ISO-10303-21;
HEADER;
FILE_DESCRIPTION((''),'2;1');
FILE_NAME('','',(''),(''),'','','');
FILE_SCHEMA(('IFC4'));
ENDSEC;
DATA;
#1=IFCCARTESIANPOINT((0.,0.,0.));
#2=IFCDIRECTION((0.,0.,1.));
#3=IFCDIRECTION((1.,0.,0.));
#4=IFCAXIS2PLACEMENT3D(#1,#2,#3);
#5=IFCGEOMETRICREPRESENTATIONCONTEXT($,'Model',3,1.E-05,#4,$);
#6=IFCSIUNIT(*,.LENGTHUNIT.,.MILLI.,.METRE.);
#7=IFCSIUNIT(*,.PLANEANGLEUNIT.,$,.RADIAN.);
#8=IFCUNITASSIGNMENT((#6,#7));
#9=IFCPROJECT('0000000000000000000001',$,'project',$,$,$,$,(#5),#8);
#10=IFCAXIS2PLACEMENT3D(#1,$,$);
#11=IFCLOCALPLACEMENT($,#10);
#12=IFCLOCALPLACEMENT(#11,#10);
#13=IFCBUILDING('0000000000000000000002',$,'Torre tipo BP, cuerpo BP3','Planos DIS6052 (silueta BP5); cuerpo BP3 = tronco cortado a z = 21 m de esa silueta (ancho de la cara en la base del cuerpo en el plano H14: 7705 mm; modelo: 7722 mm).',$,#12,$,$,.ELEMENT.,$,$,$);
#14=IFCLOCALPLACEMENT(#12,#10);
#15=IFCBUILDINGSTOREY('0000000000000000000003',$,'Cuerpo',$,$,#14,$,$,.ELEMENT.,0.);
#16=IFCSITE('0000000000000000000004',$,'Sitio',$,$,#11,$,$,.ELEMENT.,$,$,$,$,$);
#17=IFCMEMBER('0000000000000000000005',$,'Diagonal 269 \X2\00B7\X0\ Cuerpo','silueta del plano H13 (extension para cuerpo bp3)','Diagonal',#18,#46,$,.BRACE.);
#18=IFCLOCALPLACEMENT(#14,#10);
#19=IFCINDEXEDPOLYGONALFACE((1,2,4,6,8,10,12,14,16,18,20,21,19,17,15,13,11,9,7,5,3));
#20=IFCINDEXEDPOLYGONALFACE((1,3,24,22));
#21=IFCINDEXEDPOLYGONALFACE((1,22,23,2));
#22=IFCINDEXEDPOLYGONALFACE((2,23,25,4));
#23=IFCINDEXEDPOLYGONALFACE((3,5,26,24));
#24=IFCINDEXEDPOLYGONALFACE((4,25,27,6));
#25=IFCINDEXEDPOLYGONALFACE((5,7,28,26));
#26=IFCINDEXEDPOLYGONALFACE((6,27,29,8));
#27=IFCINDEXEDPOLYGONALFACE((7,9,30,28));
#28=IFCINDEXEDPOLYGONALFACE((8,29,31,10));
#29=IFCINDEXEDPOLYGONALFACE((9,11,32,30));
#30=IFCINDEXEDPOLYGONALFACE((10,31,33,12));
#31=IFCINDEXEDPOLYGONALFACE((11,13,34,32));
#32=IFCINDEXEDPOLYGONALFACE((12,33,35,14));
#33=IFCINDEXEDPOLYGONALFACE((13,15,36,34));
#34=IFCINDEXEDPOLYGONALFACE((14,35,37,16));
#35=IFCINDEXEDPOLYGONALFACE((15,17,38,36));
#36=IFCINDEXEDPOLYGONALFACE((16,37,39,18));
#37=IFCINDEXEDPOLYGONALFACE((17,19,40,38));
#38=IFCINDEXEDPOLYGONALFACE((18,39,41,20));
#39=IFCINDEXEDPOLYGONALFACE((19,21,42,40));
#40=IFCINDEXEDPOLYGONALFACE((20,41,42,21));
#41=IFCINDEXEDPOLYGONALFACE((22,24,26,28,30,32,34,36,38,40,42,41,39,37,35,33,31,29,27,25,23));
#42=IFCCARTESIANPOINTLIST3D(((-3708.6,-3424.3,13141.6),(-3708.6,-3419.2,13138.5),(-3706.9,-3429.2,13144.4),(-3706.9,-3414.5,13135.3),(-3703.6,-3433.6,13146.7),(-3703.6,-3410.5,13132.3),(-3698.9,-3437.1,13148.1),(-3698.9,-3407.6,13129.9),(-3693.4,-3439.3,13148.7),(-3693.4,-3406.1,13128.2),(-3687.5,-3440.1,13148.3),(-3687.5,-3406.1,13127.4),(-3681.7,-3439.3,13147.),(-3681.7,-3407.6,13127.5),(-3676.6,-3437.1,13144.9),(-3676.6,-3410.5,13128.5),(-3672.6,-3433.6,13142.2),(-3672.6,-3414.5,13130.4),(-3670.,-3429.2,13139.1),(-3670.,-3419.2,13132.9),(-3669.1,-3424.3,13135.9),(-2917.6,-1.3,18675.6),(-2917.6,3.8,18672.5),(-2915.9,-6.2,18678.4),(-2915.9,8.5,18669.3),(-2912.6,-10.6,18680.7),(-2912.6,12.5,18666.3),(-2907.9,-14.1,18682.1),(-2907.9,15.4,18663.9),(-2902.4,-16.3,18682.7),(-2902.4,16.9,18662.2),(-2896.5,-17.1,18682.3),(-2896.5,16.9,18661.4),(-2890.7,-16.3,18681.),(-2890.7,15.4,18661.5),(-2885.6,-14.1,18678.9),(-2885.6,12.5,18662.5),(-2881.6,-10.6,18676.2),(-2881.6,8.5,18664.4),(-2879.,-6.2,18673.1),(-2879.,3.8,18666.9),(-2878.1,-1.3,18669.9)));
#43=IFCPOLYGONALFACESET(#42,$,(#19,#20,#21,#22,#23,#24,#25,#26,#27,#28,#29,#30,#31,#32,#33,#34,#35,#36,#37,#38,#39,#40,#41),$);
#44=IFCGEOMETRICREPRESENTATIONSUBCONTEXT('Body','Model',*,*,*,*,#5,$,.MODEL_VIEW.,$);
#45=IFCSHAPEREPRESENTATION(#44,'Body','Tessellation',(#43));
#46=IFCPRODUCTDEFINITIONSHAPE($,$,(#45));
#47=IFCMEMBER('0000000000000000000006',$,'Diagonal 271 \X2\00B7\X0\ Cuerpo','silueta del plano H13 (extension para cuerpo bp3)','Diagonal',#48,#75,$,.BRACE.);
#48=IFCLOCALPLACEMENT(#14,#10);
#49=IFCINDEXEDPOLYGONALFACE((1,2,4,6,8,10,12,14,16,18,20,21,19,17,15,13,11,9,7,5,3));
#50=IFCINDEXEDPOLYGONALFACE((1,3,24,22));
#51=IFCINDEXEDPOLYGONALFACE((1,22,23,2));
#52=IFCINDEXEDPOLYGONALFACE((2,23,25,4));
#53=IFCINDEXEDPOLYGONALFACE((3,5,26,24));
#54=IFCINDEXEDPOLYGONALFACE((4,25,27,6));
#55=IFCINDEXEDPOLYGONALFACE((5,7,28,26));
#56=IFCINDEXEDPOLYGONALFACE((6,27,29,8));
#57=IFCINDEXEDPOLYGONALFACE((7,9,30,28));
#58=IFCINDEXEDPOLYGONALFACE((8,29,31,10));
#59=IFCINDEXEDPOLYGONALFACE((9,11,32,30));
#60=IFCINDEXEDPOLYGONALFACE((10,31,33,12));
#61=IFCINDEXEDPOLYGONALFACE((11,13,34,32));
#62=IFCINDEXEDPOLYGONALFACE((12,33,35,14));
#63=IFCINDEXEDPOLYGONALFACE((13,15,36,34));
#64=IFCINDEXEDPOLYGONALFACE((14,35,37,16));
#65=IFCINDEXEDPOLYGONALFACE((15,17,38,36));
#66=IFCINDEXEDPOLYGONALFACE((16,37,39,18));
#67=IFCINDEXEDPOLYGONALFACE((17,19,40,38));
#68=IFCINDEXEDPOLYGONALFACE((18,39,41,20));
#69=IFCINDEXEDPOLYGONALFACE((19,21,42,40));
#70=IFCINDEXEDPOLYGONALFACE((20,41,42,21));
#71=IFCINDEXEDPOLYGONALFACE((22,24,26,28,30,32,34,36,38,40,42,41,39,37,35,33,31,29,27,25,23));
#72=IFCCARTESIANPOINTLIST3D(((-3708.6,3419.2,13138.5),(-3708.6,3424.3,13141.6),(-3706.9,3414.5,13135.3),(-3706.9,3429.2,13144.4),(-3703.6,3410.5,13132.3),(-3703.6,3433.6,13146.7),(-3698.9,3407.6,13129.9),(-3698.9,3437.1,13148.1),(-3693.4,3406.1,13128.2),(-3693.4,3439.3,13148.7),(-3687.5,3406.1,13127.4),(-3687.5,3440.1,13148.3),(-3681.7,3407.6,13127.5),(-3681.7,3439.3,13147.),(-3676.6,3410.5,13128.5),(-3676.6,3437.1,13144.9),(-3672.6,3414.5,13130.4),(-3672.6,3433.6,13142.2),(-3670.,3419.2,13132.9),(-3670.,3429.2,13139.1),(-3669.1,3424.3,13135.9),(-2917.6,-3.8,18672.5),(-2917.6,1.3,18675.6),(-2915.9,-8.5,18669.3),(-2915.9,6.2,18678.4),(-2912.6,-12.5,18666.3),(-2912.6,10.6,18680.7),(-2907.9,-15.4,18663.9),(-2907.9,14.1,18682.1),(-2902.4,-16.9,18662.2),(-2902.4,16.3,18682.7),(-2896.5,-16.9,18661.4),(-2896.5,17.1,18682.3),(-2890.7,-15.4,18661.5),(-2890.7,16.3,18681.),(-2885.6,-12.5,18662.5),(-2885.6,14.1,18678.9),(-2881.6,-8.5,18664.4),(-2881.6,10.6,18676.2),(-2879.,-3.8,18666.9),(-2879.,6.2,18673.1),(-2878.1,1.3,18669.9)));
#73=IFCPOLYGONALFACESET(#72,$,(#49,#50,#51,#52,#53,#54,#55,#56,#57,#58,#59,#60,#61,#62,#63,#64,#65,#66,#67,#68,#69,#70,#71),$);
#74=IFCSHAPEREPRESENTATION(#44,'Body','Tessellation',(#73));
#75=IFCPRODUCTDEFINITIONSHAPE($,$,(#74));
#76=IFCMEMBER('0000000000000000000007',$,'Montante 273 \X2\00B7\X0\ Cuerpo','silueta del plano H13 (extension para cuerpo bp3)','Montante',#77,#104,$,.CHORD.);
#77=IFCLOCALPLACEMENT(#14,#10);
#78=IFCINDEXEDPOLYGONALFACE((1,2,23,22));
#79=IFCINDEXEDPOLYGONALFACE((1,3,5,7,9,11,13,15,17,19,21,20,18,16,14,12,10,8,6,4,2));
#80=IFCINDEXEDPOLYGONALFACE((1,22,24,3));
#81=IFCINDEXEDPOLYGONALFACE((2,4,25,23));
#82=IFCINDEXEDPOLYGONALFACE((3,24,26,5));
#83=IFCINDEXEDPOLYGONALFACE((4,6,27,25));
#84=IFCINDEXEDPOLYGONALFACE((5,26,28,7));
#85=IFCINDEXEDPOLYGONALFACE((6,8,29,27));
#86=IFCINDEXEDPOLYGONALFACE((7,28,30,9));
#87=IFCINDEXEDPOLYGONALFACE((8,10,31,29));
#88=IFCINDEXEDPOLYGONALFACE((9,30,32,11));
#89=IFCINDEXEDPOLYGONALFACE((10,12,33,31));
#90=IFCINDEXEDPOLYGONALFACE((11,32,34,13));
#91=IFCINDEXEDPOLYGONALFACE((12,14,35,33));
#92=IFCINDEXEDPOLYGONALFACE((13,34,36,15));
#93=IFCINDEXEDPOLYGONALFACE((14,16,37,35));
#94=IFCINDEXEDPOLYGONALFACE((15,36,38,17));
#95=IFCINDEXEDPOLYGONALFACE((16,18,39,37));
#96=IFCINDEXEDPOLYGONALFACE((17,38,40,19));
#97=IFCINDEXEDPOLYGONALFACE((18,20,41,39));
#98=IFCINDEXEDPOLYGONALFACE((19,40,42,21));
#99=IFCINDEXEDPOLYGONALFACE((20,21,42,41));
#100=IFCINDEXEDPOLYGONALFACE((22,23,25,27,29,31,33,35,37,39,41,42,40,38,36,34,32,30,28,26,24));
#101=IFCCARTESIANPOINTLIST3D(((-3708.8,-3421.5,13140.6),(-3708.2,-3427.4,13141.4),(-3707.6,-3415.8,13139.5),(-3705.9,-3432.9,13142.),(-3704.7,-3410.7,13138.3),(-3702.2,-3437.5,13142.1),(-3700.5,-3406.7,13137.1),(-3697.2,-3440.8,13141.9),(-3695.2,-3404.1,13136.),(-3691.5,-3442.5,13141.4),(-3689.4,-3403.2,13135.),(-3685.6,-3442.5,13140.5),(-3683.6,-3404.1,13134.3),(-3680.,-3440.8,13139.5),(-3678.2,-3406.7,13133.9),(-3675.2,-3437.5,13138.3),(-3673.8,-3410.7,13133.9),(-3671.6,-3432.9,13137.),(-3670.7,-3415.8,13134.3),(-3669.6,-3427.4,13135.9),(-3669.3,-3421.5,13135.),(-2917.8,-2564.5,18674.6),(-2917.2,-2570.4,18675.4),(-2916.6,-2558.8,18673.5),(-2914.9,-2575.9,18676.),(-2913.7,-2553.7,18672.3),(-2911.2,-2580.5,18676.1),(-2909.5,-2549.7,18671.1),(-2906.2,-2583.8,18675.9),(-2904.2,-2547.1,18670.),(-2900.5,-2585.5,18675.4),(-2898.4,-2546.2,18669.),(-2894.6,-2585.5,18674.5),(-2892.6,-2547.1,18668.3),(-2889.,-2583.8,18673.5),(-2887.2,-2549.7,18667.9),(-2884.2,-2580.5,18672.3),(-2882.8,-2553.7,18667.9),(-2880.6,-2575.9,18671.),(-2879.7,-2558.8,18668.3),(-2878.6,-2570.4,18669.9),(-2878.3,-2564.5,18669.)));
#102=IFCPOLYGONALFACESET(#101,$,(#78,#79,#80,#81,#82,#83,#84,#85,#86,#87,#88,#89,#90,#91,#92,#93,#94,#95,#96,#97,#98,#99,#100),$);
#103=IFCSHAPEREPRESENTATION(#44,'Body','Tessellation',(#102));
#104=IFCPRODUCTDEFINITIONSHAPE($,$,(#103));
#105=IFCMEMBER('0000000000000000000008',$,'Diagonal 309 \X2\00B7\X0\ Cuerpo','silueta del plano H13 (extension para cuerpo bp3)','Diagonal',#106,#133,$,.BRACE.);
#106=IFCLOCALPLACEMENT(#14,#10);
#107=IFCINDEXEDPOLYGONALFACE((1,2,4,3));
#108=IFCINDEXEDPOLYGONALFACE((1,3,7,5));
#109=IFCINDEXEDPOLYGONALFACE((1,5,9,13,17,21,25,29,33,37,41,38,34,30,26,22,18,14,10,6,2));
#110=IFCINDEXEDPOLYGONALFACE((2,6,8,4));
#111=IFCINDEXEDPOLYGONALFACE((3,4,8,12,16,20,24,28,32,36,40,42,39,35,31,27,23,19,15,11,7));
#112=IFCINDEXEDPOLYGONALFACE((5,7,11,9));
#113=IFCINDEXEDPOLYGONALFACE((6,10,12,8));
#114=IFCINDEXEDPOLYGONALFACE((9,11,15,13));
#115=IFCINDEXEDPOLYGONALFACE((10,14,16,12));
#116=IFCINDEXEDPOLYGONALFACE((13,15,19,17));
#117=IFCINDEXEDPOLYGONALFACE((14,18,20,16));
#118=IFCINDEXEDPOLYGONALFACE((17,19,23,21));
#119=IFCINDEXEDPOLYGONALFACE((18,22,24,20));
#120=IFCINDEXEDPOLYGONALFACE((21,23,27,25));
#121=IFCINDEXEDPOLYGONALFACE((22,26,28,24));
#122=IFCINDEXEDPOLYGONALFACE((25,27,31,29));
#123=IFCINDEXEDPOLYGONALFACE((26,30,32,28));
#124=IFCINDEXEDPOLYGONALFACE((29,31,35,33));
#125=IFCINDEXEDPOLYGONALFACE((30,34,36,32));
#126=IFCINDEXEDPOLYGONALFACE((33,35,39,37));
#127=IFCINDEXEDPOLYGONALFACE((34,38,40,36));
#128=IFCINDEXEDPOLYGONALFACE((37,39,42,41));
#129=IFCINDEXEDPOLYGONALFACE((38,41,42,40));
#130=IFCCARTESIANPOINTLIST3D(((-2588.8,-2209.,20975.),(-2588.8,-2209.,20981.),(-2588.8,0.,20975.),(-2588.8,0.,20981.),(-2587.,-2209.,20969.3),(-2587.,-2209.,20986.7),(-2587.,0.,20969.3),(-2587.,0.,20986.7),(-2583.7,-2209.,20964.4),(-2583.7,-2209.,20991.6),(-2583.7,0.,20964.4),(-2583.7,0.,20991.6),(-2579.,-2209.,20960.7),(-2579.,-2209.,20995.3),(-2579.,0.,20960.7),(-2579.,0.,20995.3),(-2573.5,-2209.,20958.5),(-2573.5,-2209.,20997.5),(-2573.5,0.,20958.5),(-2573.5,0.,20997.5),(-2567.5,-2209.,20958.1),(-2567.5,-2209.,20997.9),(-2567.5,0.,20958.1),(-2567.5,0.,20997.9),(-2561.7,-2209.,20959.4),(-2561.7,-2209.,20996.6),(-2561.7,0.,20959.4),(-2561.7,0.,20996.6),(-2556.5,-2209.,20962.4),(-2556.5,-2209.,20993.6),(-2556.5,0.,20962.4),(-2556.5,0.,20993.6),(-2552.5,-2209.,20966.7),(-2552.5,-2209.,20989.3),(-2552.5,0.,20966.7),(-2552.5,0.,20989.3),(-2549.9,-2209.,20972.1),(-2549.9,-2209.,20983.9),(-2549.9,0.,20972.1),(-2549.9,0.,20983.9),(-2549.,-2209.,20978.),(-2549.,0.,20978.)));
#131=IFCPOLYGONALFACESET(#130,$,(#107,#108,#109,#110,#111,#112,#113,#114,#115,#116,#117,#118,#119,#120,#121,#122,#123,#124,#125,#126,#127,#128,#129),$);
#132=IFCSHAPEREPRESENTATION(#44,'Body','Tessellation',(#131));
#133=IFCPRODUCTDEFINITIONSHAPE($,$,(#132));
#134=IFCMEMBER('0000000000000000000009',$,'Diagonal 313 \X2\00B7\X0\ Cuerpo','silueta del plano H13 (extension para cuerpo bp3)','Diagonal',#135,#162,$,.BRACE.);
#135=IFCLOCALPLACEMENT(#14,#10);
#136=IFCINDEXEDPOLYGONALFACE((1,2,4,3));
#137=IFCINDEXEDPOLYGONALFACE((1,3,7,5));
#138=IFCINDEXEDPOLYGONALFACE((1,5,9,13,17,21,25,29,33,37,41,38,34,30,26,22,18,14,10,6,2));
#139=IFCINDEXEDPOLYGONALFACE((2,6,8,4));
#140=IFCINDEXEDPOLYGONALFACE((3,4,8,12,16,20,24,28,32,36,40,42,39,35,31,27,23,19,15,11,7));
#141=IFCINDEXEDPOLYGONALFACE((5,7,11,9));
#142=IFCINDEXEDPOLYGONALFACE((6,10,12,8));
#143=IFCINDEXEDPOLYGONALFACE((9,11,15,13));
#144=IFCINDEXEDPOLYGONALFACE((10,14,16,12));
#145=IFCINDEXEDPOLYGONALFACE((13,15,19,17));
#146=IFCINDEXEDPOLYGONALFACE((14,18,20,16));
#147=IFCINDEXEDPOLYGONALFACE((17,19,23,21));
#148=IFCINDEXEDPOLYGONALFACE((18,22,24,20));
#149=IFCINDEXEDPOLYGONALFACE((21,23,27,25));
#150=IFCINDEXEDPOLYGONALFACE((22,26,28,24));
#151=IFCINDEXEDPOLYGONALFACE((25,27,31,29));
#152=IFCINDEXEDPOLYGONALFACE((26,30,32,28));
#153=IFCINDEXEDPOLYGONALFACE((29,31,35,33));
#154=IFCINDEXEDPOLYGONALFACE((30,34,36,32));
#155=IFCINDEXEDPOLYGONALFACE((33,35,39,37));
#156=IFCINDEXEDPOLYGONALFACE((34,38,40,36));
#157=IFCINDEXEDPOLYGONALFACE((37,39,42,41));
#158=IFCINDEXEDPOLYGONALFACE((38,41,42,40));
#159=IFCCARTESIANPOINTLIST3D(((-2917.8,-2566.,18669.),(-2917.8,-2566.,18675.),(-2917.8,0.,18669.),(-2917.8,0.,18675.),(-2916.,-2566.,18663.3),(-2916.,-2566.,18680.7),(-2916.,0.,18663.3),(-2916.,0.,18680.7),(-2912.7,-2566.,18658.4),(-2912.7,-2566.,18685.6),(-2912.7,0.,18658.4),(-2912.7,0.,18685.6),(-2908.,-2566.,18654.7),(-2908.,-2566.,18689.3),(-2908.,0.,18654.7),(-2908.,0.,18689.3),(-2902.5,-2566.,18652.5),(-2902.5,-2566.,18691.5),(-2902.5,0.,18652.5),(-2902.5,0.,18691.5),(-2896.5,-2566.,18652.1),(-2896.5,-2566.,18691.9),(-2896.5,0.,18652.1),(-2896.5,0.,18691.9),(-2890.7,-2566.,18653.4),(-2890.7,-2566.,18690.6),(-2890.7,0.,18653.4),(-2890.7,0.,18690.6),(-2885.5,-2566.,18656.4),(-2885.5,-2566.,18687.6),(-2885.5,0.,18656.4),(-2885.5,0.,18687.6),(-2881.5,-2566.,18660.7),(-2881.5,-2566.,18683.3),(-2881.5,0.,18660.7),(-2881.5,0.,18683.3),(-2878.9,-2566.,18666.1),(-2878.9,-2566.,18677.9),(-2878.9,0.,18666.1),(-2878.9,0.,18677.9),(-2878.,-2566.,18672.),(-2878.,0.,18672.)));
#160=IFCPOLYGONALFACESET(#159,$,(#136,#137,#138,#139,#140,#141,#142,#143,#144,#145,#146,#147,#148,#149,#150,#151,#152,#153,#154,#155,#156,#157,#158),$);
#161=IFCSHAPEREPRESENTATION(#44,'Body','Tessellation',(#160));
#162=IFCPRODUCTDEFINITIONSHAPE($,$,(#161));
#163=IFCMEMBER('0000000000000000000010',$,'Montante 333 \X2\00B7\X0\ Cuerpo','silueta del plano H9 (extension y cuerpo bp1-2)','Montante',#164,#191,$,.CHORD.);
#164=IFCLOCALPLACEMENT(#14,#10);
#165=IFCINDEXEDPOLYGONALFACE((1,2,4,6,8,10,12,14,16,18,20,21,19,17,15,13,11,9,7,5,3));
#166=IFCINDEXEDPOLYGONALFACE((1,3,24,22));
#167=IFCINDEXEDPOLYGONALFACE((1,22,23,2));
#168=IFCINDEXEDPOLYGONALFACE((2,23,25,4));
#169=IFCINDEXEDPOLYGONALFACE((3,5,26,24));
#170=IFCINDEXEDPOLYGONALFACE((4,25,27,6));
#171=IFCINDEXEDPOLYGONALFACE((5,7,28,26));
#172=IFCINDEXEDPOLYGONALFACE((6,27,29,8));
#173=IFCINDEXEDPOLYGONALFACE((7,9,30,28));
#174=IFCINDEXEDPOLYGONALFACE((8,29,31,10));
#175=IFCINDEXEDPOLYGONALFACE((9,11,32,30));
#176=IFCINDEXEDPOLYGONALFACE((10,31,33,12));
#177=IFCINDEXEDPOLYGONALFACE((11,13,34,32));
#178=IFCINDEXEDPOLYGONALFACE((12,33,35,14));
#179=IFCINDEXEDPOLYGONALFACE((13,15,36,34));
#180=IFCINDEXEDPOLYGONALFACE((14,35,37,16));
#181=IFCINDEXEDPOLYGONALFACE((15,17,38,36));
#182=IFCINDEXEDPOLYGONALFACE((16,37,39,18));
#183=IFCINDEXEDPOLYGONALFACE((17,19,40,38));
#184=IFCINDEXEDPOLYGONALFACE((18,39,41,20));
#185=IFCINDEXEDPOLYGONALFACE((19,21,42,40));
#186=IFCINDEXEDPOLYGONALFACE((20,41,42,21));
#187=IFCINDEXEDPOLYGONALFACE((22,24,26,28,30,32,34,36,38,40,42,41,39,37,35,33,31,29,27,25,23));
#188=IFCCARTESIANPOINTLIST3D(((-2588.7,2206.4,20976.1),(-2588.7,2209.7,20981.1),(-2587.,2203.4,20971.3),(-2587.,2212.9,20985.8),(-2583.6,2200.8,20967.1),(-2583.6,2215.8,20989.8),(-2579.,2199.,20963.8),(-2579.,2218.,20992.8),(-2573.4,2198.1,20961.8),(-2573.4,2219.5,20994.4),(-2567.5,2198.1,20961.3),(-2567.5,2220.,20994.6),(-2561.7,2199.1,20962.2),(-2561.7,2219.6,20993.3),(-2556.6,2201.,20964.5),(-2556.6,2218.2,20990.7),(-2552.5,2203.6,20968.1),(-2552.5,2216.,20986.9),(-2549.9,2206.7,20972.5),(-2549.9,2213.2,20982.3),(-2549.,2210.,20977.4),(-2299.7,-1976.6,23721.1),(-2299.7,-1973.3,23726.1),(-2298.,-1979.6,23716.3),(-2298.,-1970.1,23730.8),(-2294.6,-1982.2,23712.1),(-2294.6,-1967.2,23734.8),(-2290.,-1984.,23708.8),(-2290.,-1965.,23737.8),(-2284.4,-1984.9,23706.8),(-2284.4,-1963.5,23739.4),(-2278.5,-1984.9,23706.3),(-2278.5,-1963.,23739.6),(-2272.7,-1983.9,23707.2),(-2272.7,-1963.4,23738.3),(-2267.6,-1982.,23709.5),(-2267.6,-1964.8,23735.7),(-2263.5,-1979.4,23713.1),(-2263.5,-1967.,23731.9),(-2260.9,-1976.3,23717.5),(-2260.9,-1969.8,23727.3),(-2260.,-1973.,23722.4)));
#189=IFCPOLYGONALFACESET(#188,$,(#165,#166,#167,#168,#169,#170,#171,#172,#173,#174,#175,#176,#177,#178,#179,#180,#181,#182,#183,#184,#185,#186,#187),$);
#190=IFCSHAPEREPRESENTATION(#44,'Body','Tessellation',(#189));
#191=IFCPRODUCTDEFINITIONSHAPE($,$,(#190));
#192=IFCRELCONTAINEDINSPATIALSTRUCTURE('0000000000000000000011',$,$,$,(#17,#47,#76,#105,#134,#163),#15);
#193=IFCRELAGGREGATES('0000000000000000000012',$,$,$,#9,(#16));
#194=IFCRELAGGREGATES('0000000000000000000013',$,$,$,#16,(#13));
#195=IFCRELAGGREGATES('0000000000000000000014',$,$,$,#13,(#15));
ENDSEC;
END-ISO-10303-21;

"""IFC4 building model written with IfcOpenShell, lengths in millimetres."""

from ifc_helpers import new_model, si_unit, frame, origin, origin_with_axes, place, context, subcontext, project, spatial, circle, extrude, element, save


model = new_model("IFC4")

# Units and contexts
model_context = context("Model", 3, precision=1e-05, world=origin_with_axes())
body_context = subcontext(model_context, "Body", "Model", "MODEL_VIEW")
ifc_project = project(units=[si_unit("LENGTHUNIT", "METRE", prefix="MILLI"), si_unit("PLANEANGLEUNIT", "RADIAN")], contexts=[model_context])

# Site, building, storey
site_placement = place(None, origin())
site = spatial("IfcSite", under=ifc_project, at=site_placement, Name="Sitio", CompositionType="ELEMENT")
building_placement = place(site_placement, origin())
building = spatial("IfcBuilding", under=site, at=building_placement, Name="Torre tipo BP, cuerpo BP3", Description="Planos DIS6052 (silueta BP5); cuerpo BP3 = tronco cortado a z = 21 m de esa silueta (ancho de la cara en la base del cuerpo en el plano H14: 7705 mm; modelo: 7722 mm).", CompositionType="ELEMENT")
storey_placement = place(building_placement, origin())
storey = spatial("IfcBuildingStorey", under=building, at=storey_placement, Name="Cuerpo", CompositionType="ELEMENT", Elevation=0.0)

# Members
for number, where, z_axis, x_axis, name in (
    (1, (-2898.0, 0.0, 18672.0), (-0.120672, -0.522198, -0.844244), (0.992692, -0.063478, -0.102626), "Diagonal 269 · Cuerpo"),
    (2, (-2898.0, 0.0, 18672.0), (-0.120672, 0.522198, -0.844244), (0.992692, 0.063478, -0.102626), "Diagonal 271 · Cuerpo"),
):
    element("IfcMember", number, at=place(storey_placement, frame(where, z_axis=z_axis, x_axis=x_axis)), inside=storey, Name=name, Description="silueta del plano H13 (extension para cuerpo bp3)", ObjectType="Diagonal", PredefinedType="BRACE", context=body_context, shape_type="SweptSolid", body=[
        extrude(circle(Radius=20.0), None, (0.0, 0.0, 1.0), 6555.0),
    ])
member_1_placement = place(storey_placement, frame((-2898.0, -2566.0, 18672.0), z_axis=(-0.139863, -0.151532, -0.978507), x_axis=(-0.021441, 0.988452, -0.150008)))
element("IfcMember", 3, at=member_1_placement, inside=storey, Name="Montante 273 · Cuerpo", Description="silueta del plano H13 (extension para cuerpo bp3)", ObjectType="Montante", PredefinedType="CHORD", context=body_context, shape_type="SweptSolid", body=[
    extrude(circle(Radius=20.0), None, (0.0, 0.0, 1.0), 5655.6),
])
member_2_placement = place(storey_placement, frame((-2569.0, -2209.0, 20978.0), z_axis=(0.0, 1.0, 0.0), x_axis=(1.0, 0.0, 0.0)))
element("IfcMember", 4, at=member_2_placement, inside=storey, Name="Diagonal 309 · Cuerpo", Description="silueta del plano H13 (extension para cuerpo bp3)", ObjectType="Diagonal", PredefinedType="BRACE", context=body_context, shape_type="SweptSolid", body=[
    extrude(circle(Radius=20.0), None, (0.0, 0.0, 1.0), 2209.0),
])
member_3_placement = place(storey_placement, frame((-2898.0, -2566.0, 18672.0), z_axis=(0.0, 1.0, 0.0), x_axis=(1.0, 0.0, 0.0)))
element("IfcMember", 5, at=member_3_placement, inside=storey, Name="Diagonal 313 · Cuerpo", Description="silueta del plano H13 (extension para cuerpo bp3)", ObjectType="Diagonal", PredefinedType="BRACE", context=body_context, shape_type="SweptSolid", body=[
    extrude(circle(Radius=20.0), None, (0.0, 0.0, 1.0), 2566.0),
])
member_4_placement = place(storey_placement, frame((-2280.0, -1974.0, 23723.0), z_axis=(-0.057666, 0.834665, -0.54773), x_axis=(0.998336, 0.048212, -0.031638)))
element("IfcMember", 6, at=member_4_placement, inside=storey, Name="Montante 333 · Cuerpo", Description="silueta del plano H9 (extension y cuerpo bp1-2)", ObjectType="Montante", PredefinedType="CHORD", context=body_context, shape_type="SweptSolid", body=[
    extrude(circle(Radius=20.0), None, (0.0, 0.0, 1.0), 5011.6),
])

save(model, "model.ifc")
